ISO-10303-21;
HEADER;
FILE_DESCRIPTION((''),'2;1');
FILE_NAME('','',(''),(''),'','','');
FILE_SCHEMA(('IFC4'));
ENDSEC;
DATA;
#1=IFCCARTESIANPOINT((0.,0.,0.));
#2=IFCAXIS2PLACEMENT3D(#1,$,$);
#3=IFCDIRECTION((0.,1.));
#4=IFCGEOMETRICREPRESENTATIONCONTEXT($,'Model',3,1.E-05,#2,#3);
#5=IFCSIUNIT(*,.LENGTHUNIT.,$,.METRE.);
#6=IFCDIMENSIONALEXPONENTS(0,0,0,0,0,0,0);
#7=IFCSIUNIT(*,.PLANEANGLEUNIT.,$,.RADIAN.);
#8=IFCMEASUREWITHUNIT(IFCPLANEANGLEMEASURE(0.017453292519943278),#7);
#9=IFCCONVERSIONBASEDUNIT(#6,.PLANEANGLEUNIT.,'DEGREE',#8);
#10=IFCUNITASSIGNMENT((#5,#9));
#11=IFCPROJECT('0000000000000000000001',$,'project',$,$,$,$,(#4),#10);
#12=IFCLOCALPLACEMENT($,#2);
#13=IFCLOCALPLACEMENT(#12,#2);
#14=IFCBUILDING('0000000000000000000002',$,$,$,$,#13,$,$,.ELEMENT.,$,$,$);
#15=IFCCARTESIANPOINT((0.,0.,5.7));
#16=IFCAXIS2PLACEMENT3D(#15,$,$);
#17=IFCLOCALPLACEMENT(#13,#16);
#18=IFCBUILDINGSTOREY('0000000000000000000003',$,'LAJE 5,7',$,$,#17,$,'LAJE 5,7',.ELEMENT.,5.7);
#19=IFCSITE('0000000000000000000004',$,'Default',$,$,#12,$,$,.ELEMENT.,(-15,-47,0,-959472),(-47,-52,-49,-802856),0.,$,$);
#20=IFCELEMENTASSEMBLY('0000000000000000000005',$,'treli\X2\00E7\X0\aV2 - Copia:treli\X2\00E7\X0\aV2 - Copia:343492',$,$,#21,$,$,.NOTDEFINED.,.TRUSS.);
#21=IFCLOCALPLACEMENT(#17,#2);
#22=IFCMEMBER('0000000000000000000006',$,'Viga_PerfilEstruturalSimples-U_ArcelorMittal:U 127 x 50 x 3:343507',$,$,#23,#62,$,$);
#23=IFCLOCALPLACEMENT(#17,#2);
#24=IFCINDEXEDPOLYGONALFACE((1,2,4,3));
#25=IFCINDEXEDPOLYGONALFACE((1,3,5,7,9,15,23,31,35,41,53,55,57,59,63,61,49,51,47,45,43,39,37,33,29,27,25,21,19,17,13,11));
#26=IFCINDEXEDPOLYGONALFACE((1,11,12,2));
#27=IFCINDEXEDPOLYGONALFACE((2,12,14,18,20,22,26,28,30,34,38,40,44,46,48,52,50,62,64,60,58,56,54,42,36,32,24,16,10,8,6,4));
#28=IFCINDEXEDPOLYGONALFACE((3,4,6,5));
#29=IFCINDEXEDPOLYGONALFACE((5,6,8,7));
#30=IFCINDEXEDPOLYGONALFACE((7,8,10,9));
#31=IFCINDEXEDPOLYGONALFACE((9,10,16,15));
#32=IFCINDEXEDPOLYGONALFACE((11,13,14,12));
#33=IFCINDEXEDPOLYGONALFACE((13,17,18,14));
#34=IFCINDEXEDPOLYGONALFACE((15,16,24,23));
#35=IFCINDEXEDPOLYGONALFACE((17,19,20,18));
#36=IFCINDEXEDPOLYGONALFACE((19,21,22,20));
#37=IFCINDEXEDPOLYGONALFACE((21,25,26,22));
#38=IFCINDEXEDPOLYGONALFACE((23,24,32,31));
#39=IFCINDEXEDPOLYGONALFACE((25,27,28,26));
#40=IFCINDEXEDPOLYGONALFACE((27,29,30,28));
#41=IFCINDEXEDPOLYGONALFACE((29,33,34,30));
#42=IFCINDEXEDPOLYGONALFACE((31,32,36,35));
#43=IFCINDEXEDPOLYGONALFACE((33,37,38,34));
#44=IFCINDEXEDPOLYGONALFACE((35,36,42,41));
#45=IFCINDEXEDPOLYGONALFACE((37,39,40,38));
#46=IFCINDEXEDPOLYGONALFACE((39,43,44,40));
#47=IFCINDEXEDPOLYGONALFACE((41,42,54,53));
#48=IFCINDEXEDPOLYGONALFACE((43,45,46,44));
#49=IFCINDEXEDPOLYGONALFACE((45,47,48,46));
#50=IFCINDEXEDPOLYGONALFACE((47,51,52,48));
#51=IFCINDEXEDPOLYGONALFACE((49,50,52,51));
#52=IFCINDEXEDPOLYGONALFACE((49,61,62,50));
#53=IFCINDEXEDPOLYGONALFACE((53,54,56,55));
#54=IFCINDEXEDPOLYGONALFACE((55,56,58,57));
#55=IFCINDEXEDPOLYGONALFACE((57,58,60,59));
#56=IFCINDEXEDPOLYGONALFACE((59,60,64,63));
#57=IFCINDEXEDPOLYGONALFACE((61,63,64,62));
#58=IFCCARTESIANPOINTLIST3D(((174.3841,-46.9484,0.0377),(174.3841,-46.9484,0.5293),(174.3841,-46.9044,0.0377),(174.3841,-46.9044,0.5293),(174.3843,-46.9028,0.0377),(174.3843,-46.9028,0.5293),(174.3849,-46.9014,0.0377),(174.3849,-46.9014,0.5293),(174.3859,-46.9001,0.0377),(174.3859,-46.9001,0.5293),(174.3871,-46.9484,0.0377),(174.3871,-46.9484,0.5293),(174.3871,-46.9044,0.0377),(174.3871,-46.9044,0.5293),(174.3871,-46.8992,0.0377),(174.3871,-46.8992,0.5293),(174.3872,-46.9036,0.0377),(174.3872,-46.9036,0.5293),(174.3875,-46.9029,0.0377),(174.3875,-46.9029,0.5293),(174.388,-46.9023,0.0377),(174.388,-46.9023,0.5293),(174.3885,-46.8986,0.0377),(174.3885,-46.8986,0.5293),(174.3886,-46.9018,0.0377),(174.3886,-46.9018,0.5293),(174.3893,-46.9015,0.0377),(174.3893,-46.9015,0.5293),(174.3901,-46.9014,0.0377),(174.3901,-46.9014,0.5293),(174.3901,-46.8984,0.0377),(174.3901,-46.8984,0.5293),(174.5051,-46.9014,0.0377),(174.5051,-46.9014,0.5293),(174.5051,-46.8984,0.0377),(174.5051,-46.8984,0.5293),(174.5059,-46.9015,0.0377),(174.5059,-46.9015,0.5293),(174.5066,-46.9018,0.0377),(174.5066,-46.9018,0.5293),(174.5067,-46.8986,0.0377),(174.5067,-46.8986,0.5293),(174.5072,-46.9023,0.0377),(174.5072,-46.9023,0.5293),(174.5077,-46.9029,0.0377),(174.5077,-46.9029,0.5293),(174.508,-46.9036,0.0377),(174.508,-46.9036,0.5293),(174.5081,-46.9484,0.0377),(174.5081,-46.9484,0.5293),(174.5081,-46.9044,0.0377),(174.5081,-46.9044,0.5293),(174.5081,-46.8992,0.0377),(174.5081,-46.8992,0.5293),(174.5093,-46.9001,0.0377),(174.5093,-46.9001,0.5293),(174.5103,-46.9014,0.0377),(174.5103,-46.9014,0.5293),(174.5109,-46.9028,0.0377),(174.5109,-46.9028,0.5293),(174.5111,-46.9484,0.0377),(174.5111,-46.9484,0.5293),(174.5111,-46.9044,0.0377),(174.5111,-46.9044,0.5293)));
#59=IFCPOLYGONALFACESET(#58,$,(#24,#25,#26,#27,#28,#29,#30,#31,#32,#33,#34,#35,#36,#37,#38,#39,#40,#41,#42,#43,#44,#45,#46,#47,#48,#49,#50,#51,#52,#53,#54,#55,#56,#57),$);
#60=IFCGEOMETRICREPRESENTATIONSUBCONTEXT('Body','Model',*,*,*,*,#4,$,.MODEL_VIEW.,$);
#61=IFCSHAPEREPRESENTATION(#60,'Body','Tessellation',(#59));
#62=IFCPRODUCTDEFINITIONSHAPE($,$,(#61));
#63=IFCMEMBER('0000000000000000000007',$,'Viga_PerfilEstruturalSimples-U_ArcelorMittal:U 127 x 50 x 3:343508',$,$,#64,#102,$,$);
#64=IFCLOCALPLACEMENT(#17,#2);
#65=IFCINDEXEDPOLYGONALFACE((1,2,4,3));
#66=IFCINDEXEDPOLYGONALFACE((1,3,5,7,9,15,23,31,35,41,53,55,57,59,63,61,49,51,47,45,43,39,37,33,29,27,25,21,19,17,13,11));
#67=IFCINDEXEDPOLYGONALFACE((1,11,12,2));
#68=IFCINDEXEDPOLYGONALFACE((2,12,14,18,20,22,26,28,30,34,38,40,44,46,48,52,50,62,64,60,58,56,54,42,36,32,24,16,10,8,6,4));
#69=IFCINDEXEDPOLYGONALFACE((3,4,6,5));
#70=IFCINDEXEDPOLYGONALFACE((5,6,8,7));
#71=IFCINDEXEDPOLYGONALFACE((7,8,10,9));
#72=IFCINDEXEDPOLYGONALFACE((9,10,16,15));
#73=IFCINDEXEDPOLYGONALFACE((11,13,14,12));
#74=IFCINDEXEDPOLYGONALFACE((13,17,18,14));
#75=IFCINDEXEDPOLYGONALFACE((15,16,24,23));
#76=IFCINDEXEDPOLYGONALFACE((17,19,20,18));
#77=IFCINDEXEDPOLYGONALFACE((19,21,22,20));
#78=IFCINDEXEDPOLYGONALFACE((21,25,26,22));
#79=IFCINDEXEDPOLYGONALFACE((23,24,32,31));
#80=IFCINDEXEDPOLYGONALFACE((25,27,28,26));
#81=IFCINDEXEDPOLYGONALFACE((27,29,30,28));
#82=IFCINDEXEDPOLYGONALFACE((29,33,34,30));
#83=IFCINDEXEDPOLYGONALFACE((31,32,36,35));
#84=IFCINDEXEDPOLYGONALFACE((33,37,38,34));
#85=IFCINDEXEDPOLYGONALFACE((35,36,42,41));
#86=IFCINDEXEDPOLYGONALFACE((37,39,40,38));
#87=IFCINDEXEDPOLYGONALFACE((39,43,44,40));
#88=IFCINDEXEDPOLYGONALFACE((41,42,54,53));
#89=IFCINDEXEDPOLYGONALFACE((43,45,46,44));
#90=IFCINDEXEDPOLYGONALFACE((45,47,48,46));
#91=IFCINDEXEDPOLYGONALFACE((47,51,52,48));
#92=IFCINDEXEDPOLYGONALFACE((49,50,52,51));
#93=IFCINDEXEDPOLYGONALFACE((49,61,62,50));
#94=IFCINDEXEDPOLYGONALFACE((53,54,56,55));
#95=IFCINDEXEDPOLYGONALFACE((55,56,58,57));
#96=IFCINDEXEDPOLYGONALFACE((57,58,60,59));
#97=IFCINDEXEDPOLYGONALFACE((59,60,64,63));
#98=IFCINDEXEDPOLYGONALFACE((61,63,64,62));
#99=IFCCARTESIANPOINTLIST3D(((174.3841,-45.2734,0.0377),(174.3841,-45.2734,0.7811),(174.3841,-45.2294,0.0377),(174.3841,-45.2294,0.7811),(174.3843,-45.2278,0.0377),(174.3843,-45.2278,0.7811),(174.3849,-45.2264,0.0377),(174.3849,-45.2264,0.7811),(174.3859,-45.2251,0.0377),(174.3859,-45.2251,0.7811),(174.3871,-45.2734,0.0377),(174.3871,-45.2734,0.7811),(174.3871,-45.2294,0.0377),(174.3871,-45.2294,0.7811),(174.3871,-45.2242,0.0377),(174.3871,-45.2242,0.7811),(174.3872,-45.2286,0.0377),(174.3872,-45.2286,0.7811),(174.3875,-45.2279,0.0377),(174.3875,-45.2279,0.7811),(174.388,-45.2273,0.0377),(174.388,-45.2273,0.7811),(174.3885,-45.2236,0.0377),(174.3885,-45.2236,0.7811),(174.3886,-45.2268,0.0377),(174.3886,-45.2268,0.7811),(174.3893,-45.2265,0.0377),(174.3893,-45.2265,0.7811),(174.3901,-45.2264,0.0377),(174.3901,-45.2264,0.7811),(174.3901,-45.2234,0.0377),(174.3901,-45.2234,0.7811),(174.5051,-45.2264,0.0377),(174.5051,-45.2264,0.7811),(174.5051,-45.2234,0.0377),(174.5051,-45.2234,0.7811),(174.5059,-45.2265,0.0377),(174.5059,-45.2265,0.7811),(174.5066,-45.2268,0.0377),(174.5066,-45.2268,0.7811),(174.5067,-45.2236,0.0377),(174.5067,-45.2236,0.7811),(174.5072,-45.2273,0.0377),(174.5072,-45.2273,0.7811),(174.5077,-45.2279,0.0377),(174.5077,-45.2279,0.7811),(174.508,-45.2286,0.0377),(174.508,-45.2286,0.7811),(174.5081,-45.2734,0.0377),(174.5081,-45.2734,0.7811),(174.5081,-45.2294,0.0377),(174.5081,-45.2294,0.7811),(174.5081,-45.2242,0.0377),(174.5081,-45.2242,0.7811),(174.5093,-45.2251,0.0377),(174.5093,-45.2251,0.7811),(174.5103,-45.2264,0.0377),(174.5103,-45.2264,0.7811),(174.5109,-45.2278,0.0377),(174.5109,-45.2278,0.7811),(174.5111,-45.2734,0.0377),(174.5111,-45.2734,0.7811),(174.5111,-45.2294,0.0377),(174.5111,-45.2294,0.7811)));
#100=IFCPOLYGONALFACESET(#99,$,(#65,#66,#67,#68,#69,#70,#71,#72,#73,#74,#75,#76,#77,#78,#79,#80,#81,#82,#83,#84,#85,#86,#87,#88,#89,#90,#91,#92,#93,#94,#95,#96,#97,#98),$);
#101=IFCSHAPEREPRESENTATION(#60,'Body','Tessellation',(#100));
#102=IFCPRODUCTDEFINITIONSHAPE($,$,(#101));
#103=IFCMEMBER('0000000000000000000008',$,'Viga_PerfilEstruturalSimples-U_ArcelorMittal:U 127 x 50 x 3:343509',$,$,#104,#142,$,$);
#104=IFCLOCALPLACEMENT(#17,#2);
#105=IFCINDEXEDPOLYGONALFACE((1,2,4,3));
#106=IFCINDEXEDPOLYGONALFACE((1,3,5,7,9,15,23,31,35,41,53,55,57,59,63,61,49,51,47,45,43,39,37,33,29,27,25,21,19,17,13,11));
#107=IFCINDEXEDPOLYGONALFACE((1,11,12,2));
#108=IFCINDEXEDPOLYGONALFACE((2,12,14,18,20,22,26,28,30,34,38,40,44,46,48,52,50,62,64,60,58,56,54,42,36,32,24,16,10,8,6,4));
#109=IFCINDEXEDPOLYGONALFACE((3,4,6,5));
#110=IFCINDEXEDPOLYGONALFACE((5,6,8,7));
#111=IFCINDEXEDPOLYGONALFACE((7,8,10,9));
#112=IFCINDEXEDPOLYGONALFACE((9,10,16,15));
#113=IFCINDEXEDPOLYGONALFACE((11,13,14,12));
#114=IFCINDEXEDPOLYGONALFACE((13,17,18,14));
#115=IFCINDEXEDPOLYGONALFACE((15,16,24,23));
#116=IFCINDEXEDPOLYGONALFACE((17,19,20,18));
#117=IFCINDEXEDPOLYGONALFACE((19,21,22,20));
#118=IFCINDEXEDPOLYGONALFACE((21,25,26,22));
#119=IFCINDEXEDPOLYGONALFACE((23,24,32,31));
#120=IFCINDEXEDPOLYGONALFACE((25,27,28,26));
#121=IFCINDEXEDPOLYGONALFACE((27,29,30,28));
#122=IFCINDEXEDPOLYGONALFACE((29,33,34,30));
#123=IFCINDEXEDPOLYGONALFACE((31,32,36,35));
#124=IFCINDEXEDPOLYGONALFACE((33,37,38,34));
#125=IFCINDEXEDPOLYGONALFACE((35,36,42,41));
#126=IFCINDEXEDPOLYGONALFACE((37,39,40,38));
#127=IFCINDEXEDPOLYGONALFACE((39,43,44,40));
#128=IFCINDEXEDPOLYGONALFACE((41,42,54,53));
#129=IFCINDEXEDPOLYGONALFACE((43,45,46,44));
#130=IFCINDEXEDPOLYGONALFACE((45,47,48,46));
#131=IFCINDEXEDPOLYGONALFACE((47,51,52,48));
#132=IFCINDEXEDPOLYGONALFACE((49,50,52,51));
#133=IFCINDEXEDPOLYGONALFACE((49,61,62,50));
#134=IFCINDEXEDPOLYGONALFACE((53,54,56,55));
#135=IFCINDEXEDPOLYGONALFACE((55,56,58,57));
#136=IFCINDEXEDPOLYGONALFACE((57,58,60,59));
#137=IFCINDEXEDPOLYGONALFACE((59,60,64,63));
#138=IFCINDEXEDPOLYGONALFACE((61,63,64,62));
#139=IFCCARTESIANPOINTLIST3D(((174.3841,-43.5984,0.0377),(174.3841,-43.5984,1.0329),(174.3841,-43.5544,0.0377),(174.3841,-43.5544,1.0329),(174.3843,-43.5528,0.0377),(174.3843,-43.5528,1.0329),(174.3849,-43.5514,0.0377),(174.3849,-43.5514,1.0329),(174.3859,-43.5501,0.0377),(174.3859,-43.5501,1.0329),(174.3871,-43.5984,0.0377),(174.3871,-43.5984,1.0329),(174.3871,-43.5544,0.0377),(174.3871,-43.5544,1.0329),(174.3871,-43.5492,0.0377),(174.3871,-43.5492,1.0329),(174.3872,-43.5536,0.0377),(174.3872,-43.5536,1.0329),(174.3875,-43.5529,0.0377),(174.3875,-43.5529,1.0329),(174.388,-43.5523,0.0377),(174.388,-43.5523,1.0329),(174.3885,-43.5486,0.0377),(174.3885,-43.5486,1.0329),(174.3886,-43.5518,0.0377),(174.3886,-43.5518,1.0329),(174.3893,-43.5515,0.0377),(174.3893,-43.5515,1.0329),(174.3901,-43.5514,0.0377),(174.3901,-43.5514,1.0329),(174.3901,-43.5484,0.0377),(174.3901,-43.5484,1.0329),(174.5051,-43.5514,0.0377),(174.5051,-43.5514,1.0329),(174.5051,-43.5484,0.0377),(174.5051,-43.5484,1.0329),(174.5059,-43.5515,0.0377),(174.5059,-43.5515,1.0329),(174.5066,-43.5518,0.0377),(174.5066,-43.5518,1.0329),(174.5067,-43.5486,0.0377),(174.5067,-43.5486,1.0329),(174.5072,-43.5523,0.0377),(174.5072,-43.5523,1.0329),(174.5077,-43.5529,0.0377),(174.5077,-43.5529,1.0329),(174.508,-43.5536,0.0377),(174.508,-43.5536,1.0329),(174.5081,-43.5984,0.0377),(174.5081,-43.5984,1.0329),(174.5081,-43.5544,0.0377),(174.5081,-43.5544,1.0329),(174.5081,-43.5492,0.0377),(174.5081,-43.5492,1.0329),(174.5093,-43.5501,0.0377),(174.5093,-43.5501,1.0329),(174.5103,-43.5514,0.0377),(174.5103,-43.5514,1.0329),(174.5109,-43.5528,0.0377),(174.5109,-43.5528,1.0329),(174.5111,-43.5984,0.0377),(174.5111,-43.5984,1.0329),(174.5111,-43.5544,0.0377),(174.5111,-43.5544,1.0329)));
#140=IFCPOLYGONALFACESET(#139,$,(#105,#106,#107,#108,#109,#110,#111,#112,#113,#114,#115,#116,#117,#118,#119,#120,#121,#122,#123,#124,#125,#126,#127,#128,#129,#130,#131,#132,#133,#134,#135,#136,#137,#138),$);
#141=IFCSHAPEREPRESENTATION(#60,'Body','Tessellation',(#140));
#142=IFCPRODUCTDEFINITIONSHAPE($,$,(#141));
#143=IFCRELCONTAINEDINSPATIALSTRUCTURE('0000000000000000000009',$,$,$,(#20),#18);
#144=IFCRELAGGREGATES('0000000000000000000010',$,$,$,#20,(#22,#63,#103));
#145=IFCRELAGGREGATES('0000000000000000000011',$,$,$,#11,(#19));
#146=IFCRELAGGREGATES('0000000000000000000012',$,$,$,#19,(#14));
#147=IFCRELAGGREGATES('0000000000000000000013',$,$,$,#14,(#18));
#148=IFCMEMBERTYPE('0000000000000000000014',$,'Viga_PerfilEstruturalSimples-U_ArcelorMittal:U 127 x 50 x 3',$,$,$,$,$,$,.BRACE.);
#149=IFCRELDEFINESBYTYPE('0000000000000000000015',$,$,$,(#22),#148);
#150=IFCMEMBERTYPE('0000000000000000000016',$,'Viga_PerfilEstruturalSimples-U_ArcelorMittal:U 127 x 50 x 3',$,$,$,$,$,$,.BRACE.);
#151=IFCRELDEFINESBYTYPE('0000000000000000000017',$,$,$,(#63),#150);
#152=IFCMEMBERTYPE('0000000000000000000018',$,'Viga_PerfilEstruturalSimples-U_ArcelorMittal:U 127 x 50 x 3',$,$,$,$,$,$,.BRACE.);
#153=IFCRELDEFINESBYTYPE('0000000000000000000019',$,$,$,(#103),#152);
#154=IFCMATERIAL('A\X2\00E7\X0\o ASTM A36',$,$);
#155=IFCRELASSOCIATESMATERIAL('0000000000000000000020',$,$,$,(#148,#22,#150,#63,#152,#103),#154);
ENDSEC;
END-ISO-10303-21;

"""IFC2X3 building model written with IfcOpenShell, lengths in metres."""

from ifc_helpers import new_model, entity, si_unit, converted_unit, direction, frame, frame_2d, origin, place, context, subcontext, project, spatial, polyline, circle_curve, parameter, trimmed, segment, composite_curve, outline, extrude, source, transform, mapped, material, type_object, type_shapes, element, aggregate, save


model = new_model("IFC2X3")

# Units and contexts
model_context = context("Model", 3, precision=1e-05, world=origin(), true_north=direction((0.0, 1.0)))
body_context = subcontext(model_context, "Body", "Model", "MODEL_VIEW")
ifc_project = project(units=[si_unit("LENGTHUNIT", "METRE"), converted_unit("PLANEANGLEUNIT", "DEGREE", entity("IfcPlaneAngleMeasure", 0.017453292519943278), si_unit("PLANEANGLEUNIT", "RADIAN"), dimensions=[0, 0, 0, 0, 0, 0, 0])], contexts=[model_context])

# Site, building, storey
site_placement = place(None, origin())
site = spatial("IfcSite", under=ifc_project, at=site_placement, Name="Default", CompositionType="ELEMENT", RefLatitude=(-15, -47, 0, -959472), RefLongitude=(-47, -52, -49, -802856), RefElevation=0.0)
building_placement = place(site_placement, origin())
building = spatial("IfcBuilding", under=site, at=building_placement, CompositionType="ELEMENT")
storey_placement = place(building_placement, frame((0.0, 0.0, 5.7)))
storey = spatial("IfcBuildingStorey", under=building, at=storey_placement, Name="LAJE 5,7", LongName="LAJE 5,7", CompositionType="ELEMENT", Elevation=5.7)

# Element assembly, member
assembly_1_placement = place(storey_placement, origin())
assembly_1 = element("IfcElementAssembly", 1, at=assembly_1_placement, inside=storey, Name="treliçaV2 - Copia:treliçaV2 - Copia:343492", AssemblyPlace="NOTDEFINED", PredefinedType="TRUSS")
ifc_material = material(Name="Aço ASTM A36")
member_type_1 = type_object("IfcMemberType", Name="Viga_PerfilEstruturalSimples-U_ArcelorMittal:U 127 x 50 x 3", PredefinedType="BRACE", material=ifc_material)
shared_shape_1 = source(origin(), body_context, "Body", "SweptSolid", [
    extrude(outline(composite_curve([segment(polyline([(-0.0575, -0.0192), (0.0575, -0.0192)]), True, "CONTINUOUS"), segment(trimmed(circle_curve(frame_2d((0.0575, -0.0132), x_axis=(0.0, 1.0)), 0.006), [parameter(180.0)], [parameter(270.0)], True, "PARAMETER"), True, "CONTINUOUS"), segment(polyline([(0.0635, -0.0132), (0.0635, 0.0308)]), True, "CONTINUOUS"), segment(polyline([(0.0635, 0.0308), (0.0605, 0.0308)]), True, "CONTINUOUS"), segment(polyline([(0.0605, 0.0308), (0.0605, -0.0132)]), True, "CONTINUOUS"), segment(trimmed(circle_curve(frame_2d((0.0575, -0.0132), x_axis=(0.0, 1.0)), 0.003), [parameter(180.0)], [parameter(270.0)], True, "PARAMETER"), False, "CONTINUOUS"), segment(polyline([(0.0575, -0.0162), (-0.0575, -0.0162)]), True, "CONTINUOUS"), segment(trimmed(circle_curve(frame_2d((-0.0575, -0.0132), x_axis=(0.0, 1.0)), 0.003), [parameter(90.0)], [parameter(180.0)], True, "PARAMETER"), False, "CONTINUOUS"), segment(polyline([(-0.0605, -0.0132), (-0.0605, 0.0308)]), True, "CONTINUOUS"), segment(polyline([(-0.0605, 0.0308), (-0.0635, 0.0308)]), True, "CONTINUOUS"), segment(polyline([(-0.0635, 0.0308), (-0.0635, -0.0132)]), True, "CONTINUOUS"), segment(trimmed(circle_curve(frame_2d((-0.0575, -0.0132), x_axis=(0.0, 1.0)), 0.006), [parameter(90.0)], [parameter(180.0)], True, "PARAMETER"), True, "CONTINUOUS")], self_intersect=False)), frame((-0.2478, -0.0058, 0.0), z_axis=(1.0, 0.0, 0.0), x_axis=(0.0, 0.0, -1.0)), (0.0, 0.0, 1.0), 0.4916),
])
type_shapes(member_type_1, [shared_shape_1])
member_1_placement = place(assembly_1_placement, frame((174.4476, -46.9234, 0.2855), z_axis=(1.0, 0.0, 0.0), x_axis=(0.0, 0.0, 1.0)))
member_1 = element("IfcMember", 2, at=member_1_placement, type_object=member_type_1, material=ifc_material, Name="Viga_PerfilEstruturalSimples-U_ArcelorMittal:U 127 x 50 x 3:343507", context=body_context, shape_type="MappedRepresentation", body=[
    mapped(shared_shape_1, transform((0.0, 0.0, 0.0), scale=1.0)),
])

# Shared definitions
member_type_2 = type_object("IfcMemberType", Name="Viga_PerfilEstruturalSimples-U_ArcelorMittal:U 127 x 50 x 3", PredefinedType="BRACE", material=ifc_material)
shared_shape_2 = source(origin(), body_context, "Body", "SweptSolid", [
    extrude(outline(composite_curve([segment(polyline([(-0.0575, -0.0192), (0.0575, -0.0192)]), True, "CONTINUOUS"), segment(trimmed(circle_curve(frame_2d((0.0575, -0.0132), x_axis=(0.0, 1.0)), 0.006), [parameter(180.0)], [parameter(270.0)], True, "PARAMETER"), True, "CONTINUOUS"), segment(polyline([(0.0635, -0.0132), (0.0635, 0.0308)]), True, "CONTINUOUS"), segment(polyline([(0.0635, 0.0308), (0.0605, 0.0308)]), True, "CONTINUOUS"), segment(polyline([(0.0605, 0.0308), (0.0605, -0.0132)]), True, "CONTINUOUS"), segment(trimmed(circle_curve(frame_2d((0.0575, -0.0132), x_axis=(0.0, 1.0)), 0.003), [parameter(180.0)], [parameter(270.0)], True, "PARAMETER"), False, "CONTINUOUS"), segment(polyline([(0.0575, -0.0162), (-0.0575, -0.0162)]), True, "CONTINUOUS"), segment(trimmed(circle_curve(frame_2d((-0.0575, -0.0132), x_axis=(0.0, 1.0)), 0.003), [parameter(90.0)], [parameter(180.0)], True, "PARAMETER"), False, "CONTINUOUS"), segment(polyline([(-0.0605, -0.0132), (-0.0605, 0.0308)]), True, "CONTINUOUS"), segment(polyline([(-0.0605, 0.0308), (-0.0635, 0.0308)]), True, "CONTINUOUS"), segment(polyline([(-0.0635, 0.0308), (-0.0635, -0.0132)]), True, "CONTINUOUS"), segment(trimmed(circle_curve(frame_2d((-0.0575, -0.0132), x_axis=(0.0, 1.0)), 0.006), [parameter(90.0)], [parameter(180.0)], True, "PARAMETER"), True, "CONTINUOUS")], self_intersect=False)), frame((-0.3737, -0.0058, 0.0), z_axis=(1.0, 0.0, 0.0), x_axis=(0.0, 0.0, -1.0)), (0.0, 0.0, 1.0), 0.7434),
])
type_shapes(member_type_2, [shared_shape_2])

# Members
member_2_placement = place(assembly_1_placement, frame((174.4476, -45.2484, 0.4114), z_axis=(1.0, 0.0, 0.0), x_axis=(0.0, 0.0, 1.0)))
member_2 = element("IfcMember", 3, at=member_2_placement, type_object=member_type_2, material=ifc_material, Name="Viga_PerfilEstruturalSimples-U_ArcelorMittal:U 127 x 50 x 3:343508", context=body_context, shape_type="MappedRepresentation", body=[
    mapped(shared_shape_2, transform((0.0, 0.0, 0.0), scale=1.0)),
])
member_type_3 = type_object("IfcMemberType", Name="Viga_PerfilEstruturalSimples-U_ArcelorMittal:U 127 x 50 x 3", PredefinedType="BRACE", material=ifc_material)
shared_shape_3 = source(origin(), body_context, "Body", "SweptSolid", [
    extrude(outline(composite_curve([segment(polyline([(-0.0575, -0.0192), (0.0575, -0.0192)]), True, "CONTINUOUS"), segment(trimmed(circle_curve(frame_2d((0.0575, -0.0132), x_axis=(0.0, 1.0)), 0.006), [parameter(180.0)], [parameter(270.0)], True, "PARAMETER"), True, "CONTINUOUS"), segment(polyline([(0.0635, -0.0132), (0.0635, 0.0308)]), True, "CONTINUOUS"), segment(polyline([(0.0635, 0.0308), (0.0605, 0.0308)]), True, "CONTINUOUS"), segment(polyline([(0.0605, 0.0308), (0.0605, -0.0132)]), True, "CONTINUOUS"), segment(trimmed(circle_curve(frame_2d((0.0575, -0.0132), x_axis=(0.0, 1.0)), 0.003), [parameter(180.0)], [parameter(270.0)], True, "PARAMETER"), False, "CONTINUOUS"), segment(polyline([(0.0575, -0.0162), (-0.0575, -0.0162)]), True, "CONTINUOUS"), segment(trimmed(circle_curve(frame_2d((-0.0575, -0.0132), x_axis=(0.0, 1.0)), 0.003), [parameter(90.0)], [parameter(180.0)], True, "PARAMETER"), False, "CONTINUOUS"), segment(polyline([(-0.0605, -0.0132), (-0.0605, 0.0308)]), True, "CONTINUOUS"), segment(polyline([(-0.0605, 0.0308), (-0.0635, 0.0308)]), True, "CONTINUOUS"), segment(polyline([(-0.0635, 0.0308), (-0.0635, -0.0132)]), True, "CONTINUOUS"), segment(trimmed(circle_curve(frame_2d((-0.0575, -0.0132), x_axis=(0.0, 1.0)), 0.006), [parameter(90.0)], [parameter(180.0)], True, "PARAMETER"), True, "CONTINUOUS")], self_intersect=False)), frame((-0.4996, -0.0058, 0.0), z_axis=(1.0, 0.0, 0.0), x_axis=(0.0, 0.0, -1.0)), (0.0, 0.0, 1.0), 0.9952),
])
type_shapes(member_type_3, [shared_shape_3])
member_3_placement = place(assembly_1_placement, frame((174.4476, -43.5734, 0.5373), z_axis=(1.0, 0.0, 0.0), x_axis=(0.0, 0.0, 1.0)))
member_3 = element("IfcMember", 4, at=member_3_placement, type_object=member_type_3, material=ifc_material, Name="Viga_PerfilEstruturalSimples-U_ArcelorMittal:U 127 x 50 x 3:343509", context=body_context, shape_type="MappedRepresentation", body=[
    mapped(shared_shape_3, transform((0.0, 0.0, 0.0), scale=1.0)),
])
aggregate(assembly_1, [member_1, member_2, member_3])

save(model, "model.ifc")
